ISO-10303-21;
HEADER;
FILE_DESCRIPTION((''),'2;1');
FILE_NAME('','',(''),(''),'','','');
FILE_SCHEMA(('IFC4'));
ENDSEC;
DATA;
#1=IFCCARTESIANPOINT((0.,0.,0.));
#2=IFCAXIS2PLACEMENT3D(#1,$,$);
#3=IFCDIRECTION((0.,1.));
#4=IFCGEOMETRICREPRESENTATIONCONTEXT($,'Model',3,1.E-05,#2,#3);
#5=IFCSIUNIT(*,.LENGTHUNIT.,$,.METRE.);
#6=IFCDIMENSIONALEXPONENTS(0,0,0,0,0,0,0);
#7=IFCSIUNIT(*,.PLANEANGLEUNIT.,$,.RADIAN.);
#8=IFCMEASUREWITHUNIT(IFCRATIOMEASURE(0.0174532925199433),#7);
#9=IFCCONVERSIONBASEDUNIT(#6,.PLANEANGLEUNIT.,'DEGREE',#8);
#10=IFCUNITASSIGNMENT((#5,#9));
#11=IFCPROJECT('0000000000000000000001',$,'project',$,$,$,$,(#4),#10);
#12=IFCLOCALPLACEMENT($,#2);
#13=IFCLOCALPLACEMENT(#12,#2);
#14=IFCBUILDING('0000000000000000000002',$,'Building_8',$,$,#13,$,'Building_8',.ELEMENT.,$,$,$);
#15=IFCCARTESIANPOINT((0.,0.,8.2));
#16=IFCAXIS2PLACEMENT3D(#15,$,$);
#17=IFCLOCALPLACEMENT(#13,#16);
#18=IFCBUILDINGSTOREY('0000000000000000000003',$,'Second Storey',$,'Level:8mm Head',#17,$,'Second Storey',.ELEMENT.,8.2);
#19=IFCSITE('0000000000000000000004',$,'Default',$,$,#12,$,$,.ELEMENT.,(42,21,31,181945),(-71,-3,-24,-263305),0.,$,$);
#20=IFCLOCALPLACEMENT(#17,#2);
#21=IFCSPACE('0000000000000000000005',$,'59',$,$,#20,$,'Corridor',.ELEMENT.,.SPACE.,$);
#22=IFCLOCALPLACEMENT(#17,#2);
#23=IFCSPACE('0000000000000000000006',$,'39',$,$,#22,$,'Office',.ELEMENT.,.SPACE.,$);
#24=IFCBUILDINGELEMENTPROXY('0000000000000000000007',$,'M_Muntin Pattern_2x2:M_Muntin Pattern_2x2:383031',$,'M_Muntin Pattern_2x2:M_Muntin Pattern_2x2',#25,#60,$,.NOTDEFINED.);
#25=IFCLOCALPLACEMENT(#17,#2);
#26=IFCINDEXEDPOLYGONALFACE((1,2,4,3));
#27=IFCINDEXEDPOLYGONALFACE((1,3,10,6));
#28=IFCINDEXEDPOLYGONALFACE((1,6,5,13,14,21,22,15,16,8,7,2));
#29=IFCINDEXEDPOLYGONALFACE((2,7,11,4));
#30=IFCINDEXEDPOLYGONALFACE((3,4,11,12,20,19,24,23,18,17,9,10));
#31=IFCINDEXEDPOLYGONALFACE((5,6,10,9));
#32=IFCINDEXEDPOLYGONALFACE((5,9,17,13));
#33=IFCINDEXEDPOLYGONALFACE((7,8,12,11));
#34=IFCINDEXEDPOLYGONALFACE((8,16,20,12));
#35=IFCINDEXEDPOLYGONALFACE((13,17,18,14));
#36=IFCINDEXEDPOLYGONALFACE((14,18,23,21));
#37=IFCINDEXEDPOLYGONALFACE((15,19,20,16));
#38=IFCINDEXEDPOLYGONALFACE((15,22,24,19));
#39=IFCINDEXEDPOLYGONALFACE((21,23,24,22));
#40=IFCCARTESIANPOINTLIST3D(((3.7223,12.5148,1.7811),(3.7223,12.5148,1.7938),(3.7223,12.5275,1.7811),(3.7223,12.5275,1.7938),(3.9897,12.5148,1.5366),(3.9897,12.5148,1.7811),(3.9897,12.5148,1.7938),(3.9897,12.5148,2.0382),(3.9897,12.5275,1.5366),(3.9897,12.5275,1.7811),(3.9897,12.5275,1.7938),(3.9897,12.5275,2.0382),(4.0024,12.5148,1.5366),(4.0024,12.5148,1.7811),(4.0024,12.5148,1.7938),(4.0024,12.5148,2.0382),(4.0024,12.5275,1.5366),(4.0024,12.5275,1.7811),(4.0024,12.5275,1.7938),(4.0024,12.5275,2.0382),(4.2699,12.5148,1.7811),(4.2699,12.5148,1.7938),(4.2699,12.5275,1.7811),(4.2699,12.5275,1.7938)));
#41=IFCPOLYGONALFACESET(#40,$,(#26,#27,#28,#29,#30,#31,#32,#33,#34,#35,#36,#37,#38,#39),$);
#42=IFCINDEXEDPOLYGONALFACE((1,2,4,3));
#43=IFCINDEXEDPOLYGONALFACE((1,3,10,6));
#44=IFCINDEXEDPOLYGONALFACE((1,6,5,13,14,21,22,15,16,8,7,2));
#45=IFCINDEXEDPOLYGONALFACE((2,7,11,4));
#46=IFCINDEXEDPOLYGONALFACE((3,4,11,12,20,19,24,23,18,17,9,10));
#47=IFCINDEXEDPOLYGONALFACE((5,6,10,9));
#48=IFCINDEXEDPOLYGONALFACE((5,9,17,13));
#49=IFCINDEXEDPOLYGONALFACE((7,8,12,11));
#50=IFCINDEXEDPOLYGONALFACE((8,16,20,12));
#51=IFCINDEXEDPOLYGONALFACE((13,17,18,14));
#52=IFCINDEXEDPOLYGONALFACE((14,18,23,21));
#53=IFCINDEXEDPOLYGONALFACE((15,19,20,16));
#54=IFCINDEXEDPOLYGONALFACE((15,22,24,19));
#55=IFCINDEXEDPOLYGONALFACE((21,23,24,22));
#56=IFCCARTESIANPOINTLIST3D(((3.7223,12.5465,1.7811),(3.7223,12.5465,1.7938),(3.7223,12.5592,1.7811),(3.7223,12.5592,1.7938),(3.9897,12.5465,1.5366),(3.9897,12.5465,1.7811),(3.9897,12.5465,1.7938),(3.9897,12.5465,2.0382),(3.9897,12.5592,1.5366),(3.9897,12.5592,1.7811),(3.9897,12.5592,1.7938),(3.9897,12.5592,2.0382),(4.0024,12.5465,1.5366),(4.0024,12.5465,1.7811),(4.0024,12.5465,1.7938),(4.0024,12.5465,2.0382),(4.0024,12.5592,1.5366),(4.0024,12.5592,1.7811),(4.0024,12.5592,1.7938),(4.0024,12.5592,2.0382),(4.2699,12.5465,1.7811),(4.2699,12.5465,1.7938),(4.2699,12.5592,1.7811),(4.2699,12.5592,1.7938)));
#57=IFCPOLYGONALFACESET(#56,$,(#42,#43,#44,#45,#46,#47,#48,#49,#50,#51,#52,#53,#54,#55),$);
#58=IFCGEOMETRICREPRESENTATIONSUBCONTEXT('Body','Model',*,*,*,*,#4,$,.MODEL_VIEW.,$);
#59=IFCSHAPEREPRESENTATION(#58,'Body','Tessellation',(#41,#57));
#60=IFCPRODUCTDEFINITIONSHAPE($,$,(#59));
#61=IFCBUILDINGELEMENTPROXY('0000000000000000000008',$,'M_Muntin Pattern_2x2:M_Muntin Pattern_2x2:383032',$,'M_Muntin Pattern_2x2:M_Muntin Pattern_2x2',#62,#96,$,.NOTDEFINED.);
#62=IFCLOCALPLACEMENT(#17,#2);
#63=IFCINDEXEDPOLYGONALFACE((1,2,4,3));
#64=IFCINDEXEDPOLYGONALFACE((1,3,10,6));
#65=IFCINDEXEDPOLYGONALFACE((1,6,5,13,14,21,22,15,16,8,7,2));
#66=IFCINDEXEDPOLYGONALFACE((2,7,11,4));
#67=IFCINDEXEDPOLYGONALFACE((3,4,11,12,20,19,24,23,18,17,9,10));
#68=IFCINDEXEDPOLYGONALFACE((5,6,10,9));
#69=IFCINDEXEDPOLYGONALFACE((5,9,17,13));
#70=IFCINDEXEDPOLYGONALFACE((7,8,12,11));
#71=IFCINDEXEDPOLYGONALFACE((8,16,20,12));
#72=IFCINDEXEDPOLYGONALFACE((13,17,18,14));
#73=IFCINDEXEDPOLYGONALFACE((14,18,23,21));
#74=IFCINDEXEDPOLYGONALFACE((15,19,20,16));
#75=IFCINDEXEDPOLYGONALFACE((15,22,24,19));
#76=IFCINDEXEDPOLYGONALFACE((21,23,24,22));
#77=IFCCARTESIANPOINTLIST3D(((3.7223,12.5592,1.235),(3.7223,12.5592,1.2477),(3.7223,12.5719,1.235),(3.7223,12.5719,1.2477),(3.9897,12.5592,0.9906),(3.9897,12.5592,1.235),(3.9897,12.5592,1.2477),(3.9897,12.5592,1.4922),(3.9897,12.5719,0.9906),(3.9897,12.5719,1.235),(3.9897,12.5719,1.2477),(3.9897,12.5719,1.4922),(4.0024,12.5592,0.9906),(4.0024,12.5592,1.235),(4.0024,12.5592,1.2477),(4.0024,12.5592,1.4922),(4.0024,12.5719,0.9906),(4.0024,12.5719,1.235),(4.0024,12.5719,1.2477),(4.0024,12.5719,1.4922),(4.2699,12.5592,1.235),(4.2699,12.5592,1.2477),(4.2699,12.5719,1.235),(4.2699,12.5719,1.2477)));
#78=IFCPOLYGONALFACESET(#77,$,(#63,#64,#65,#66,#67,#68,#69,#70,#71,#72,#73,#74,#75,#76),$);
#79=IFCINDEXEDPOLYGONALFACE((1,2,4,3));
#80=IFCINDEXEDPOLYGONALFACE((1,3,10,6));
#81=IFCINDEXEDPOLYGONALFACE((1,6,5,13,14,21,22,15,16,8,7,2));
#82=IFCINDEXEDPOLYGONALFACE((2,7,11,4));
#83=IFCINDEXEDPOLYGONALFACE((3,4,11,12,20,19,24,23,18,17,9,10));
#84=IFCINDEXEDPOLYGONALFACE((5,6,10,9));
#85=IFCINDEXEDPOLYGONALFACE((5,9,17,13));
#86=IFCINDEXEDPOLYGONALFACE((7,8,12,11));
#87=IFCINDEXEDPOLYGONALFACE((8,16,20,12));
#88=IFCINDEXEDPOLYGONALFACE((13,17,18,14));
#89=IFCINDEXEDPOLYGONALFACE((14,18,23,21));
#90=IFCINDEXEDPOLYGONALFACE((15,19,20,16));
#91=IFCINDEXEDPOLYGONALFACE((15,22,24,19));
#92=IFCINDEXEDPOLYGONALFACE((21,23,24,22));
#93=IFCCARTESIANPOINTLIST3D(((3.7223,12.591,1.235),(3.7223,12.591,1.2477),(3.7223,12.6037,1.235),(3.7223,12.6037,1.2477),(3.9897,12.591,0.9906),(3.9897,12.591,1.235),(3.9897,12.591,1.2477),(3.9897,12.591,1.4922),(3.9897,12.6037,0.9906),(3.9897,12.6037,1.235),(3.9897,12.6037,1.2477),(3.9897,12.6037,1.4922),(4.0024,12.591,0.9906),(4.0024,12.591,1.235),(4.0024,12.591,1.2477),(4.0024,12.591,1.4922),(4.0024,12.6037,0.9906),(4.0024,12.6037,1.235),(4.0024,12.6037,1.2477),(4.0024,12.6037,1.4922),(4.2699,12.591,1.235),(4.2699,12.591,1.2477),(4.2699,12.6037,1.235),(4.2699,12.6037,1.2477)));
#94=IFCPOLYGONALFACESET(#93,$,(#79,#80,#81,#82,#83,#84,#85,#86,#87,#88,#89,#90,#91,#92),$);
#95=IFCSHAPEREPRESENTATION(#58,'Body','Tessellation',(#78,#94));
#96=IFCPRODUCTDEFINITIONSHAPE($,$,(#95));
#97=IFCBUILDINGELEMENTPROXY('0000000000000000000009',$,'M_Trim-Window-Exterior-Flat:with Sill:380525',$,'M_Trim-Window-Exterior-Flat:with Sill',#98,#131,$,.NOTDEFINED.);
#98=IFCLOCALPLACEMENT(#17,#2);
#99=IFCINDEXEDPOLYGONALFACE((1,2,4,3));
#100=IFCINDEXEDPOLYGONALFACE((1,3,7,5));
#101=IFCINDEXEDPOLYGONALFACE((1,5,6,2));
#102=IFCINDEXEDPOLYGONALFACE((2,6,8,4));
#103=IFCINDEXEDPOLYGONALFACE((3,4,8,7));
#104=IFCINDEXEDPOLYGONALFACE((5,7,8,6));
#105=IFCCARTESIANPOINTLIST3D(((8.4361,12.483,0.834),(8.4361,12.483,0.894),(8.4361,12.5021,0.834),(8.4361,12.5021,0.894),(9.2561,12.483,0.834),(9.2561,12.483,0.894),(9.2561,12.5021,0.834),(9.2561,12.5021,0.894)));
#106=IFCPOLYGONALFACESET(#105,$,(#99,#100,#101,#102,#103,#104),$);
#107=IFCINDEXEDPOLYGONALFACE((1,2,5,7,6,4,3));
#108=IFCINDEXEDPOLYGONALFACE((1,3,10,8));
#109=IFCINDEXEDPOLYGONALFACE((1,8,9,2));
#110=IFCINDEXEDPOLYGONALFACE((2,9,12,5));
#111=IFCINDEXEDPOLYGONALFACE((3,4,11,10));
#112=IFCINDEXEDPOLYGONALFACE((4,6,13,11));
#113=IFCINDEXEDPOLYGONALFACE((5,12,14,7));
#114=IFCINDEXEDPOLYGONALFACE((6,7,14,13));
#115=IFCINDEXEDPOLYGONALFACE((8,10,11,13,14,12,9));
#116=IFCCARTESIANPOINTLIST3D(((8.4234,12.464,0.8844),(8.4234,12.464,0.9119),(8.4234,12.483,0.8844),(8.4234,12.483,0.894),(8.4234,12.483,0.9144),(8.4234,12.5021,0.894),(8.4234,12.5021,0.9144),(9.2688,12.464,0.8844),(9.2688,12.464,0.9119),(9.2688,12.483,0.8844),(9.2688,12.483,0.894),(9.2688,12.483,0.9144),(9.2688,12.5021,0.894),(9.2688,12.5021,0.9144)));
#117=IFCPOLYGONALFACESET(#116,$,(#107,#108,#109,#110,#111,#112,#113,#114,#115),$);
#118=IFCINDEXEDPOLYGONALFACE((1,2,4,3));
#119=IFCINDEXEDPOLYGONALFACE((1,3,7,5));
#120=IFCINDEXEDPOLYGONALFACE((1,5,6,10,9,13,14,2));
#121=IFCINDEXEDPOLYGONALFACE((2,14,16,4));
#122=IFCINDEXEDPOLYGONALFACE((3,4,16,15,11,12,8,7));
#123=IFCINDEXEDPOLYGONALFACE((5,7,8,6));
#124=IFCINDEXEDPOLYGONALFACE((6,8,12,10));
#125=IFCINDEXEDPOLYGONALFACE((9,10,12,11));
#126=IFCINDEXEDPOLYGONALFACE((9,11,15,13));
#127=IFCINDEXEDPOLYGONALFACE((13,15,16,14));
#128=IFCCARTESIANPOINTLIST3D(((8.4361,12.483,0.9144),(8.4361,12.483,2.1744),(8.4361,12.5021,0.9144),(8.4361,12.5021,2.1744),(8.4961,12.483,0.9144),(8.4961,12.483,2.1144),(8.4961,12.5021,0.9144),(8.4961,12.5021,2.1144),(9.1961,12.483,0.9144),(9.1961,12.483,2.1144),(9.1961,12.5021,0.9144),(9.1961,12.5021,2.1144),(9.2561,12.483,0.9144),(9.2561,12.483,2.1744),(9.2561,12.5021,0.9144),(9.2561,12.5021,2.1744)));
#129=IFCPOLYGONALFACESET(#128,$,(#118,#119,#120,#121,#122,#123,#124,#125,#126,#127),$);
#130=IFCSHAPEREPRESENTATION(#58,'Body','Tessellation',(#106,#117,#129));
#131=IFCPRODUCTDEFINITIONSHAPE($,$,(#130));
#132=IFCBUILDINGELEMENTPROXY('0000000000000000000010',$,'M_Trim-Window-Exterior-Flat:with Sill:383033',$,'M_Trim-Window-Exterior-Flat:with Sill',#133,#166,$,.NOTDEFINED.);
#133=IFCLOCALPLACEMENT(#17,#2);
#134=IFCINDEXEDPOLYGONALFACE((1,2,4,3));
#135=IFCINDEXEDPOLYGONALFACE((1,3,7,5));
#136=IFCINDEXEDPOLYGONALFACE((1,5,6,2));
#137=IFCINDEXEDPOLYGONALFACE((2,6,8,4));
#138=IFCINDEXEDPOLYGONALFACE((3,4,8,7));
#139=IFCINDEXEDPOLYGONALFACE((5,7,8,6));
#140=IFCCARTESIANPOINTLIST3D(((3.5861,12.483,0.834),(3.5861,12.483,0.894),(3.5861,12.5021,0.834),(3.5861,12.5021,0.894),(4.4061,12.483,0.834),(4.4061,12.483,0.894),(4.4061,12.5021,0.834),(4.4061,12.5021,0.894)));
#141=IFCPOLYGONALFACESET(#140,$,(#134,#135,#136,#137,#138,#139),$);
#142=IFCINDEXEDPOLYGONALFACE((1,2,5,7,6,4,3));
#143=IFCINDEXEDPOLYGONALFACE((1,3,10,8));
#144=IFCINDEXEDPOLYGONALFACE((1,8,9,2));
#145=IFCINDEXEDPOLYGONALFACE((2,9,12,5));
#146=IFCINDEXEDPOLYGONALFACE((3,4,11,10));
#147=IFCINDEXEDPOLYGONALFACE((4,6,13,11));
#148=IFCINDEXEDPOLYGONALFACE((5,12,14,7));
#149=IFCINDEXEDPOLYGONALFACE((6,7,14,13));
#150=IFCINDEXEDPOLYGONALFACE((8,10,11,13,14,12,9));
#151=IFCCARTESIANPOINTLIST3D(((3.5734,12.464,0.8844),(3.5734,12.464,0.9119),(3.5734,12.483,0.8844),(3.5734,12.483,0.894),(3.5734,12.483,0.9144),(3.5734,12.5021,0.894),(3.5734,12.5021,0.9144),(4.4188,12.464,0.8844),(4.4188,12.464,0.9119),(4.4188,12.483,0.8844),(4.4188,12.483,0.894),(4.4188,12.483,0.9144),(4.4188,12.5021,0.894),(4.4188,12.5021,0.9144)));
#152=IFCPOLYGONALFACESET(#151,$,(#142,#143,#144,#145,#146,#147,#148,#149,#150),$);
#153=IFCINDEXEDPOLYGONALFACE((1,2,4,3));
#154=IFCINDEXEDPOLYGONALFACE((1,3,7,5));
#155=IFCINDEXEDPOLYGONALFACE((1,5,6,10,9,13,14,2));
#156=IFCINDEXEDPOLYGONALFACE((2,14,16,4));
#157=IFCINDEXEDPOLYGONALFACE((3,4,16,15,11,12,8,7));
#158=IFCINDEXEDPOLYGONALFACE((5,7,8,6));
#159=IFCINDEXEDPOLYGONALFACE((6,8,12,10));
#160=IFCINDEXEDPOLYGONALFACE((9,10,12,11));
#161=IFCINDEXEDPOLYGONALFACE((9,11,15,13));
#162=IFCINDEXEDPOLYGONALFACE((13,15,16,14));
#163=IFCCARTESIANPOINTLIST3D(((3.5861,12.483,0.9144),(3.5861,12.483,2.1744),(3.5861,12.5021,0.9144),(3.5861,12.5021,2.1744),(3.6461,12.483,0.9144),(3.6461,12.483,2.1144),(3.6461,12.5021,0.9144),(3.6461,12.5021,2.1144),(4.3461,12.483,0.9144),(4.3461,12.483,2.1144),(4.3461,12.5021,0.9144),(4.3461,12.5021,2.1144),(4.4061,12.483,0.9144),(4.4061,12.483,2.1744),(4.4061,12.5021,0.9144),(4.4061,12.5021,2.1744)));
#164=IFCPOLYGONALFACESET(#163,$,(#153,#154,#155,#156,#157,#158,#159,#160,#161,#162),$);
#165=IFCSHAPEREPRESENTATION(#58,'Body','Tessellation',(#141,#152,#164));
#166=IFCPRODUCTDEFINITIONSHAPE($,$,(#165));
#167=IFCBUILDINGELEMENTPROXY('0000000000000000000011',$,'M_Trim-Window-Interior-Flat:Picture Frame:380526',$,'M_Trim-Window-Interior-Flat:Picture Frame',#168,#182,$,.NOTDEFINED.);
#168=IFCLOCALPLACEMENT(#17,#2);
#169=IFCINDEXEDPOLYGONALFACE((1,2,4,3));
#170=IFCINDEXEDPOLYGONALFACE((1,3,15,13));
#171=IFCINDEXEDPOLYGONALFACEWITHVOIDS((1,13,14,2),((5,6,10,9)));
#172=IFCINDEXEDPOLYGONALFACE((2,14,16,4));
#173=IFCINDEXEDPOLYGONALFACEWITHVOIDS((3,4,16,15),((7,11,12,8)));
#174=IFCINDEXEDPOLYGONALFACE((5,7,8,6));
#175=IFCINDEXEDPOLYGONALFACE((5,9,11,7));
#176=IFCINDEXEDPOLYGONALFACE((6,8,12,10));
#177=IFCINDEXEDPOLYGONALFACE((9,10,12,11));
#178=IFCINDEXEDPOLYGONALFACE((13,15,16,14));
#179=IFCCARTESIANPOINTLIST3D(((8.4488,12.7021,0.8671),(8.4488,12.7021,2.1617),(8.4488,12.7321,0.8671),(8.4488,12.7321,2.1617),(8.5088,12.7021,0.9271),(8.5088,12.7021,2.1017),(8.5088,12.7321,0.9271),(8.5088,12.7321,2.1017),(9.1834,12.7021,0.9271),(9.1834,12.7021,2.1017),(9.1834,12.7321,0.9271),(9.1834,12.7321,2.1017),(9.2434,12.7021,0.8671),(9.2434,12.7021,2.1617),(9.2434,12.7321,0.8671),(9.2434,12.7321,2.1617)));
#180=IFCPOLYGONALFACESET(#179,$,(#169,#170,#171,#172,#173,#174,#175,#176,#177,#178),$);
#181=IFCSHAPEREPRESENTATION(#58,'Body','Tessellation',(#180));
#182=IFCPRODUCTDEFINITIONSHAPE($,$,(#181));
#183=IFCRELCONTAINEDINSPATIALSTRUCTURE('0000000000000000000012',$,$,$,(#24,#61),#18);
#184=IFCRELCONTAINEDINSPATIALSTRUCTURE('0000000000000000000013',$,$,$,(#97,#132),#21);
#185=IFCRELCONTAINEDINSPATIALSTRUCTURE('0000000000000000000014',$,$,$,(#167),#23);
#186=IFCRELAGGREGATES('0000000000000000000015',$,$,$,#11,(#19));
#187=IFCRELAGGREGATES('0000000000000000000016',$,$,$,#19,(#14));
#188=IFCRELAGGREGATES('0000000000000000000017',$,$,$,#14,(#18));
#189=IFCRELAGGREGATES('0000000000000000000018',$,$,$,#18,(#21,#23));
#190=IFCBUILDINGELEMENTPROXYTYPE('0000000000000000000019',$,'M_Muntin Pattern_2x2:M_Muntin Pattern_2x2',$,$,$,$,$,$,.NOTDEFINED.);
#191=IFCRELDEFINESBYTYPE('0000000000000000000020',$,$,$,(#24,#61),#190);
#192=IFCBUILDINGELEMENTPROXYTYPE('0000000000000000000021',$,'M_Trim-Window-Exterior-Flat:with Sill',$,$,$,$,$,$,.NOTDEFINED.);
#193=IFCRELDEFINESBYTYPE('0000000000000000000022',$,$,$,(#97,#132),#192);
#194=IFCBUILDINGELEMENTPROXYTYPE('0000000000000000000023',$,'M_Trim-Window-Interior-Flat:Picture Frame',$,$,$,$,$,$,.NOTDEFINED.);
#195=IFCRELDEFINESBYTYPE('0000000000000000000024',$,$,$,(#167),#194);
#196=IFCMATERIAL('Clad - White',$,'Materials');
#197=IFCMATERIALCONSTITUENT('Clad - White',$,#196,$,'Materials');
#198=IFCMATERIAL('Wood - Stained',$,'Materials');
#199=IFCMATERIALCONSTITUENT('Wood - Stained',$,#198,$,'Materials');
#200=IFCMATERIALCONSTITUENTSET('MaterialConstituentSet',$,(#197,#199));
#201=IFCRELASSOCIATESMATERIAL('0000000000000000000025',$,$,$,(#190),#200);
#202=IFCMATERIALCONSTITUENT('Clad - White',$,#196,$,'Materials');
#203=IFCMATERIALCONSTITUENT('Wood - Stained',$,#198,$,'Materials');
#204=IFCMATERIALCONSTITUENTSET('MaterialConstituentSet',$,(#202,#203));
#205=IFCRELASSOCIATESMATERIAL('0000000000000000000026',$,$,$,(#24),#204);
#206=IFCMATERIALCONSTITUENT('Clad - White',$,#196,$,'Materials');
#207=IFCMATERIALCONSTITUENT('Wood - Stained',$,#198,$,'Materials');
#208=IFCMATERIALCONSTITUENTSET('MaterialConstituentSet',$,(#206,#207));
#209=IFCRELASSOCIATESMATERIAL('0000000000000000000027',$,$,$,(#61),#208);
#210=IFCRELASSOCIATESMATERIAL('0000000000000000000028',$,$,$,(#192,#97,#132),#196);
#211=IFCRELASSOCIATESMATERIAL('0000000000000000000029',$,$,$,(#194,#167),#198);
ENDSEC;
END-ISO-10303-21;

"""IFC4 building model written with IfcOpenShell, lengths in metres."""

from ifc_helpers import new_model, entity, si_unit, converted_unit, direction, frame, origin, place, context, subcontext, project, spatial, indexed_curve, outline, extrude, source, transform, mapped, material, constituent, constituent_set, type_object, type_shapes, element, save


model = new_model("IFC4")

# Units and contexts
model_context = context("Model", 3, precision=1e-05, world=origin(), true_north=direction((0.0, 1.0)))
body_context = subcontext(model_context, "Body", "Model", "MODEL_VIEW")
ifc_project = project(units=[si_unit("LENGTHUNIT", "METRE"), converted_unit("PLANEANGLEUNIT", "DEGREE", entity("IfcRatioMeasure", 0.0174532925199433), si_unit("PLANEANGLEUNIT", "RADIAN"), dimensions=[0, 0, 0, 0, 0, 0, 0])], contexts=[model_context])

# Site, building, storey
site_placement = place(None, origin())
site = spatial("IfcSite", under=ifc_project, at=site_placement, Name="Default", CompositionType="ELEMENT", RefLatitude=(42, 21, 31, 181945), RefLongitude=(-71, -3, -24, -263305), RefElevation=0.0)
building_placement = place(site_placement, origin())
building = spatial("IfcBuilding", under=site, at=building_placement, Name="Building_8", LongName="Building_8", CompositionType="ELEMENT")
storey_placement = place(building_placement, frame((0.0, 0.0, 8.2)))
storey = spatial("IfcBuildingStorey", under=building, at=storey_placement, Name="Second Storey", ObjectType="Level:8mm Head", LongName="Second Storey", CompositionType="ELEMENT", Elevation=8.2)

# Building element proxies
ifc_material_1 = material(Name="Clad - White", Category="Materials")
ifc_material_2 = material(Name="Wood - Stained", Category="Materials")
ifc_constituent_1 = constituent(ifc_material_1, Name="Clad - White", Category="Materials")
ifc_constituent_2 = constituent(ifc_material_2, Name="Wood - Stained", Category="Materials")
ifc_constituent_set_1 = constituent_set(constituents=[ifc_constituent_1, ifc_constituent_2], Name="MaterialConstituentSet")
building_element_proxy_type_1 = type_object("IfcBuildingElementProxyType", Name="M_Muntin Pattern_2x2:M_Muntin Pattern_2x2", PredefinedType="NOTDEFINED", material=ifc_constituent_set_1)
shared_shape_1 = source(origin(), body_context, "Body", "SweptSolid", [
    extrude(outline(indexed_curve([(0.0064, -0.0064), (0.2508, -0.0064), (0.2508, 0.0063), (0.0064, 0.0063), (0.0064, 0.2738), (-0.0063, 0.2738), (-0.0063, 0.0063), (-0.2508, 0.0063), (-0.2508, -0.0064), (-0.0063, -0.0064), (-0.0063, -0.2738), (0.0064, -0.2738), (0.0064, -0.0064)], self_intersect=False)), frame((0.0, -0.0222, 0.2508), z_axis=(0.0, 1.0, 0.0), x_axis=(0.0, 0.0, 1.0)), (0.0, 0.0, 1.0), 0.0127),
    extrude(outline(indexed_curve([(0.0064, -0.0064), (0.2508, -0.0064), (0.2508, 0.0063), (0.0064, 0.0063), (0.0064, 0.2738), (-0.0063, 0.2738), (-0.0063, 0.0063), (-0.2508, 0.0063), (-0.2508, -0.0064), (-0.0063, -0.0064), (-0.0063, -0.2738), (0.0064, -0.2738), (0.0064, -0.0064)], self_intersect=False)), frame((0.0, 0.0095, 0.2508), z_axis=(0.0, 1.0, 0.0), x_axis=(0.0, 0.0, 1.0)), (0.0, 0.0, 1.0), 0.0127),
])
type_shapes(building_element_proxy_type_1, [shared_shape_1])
ifc_constituent_3 = constituent(ifc_material_1, Name="Clad - White", Category="Materials")
ifc_constituent_4 = constituent(ifc_material_2, Name="Wood - Stained", Category="Materials")
ifc_constituent_set_2 = constituent_set(constituents=[ifc_constituent_3, ifc_constituent_4], Name="MaterialConstituentSet")
proxy_1_placement = place(storey_placement, frame((3.9961, 12.537, 1.5366)))
element("IfcBuildingElementProxy", 1, at=proxy_1_placement, inside=storey, type_object=building_element_proxy_type_1, material=ifc_constituent_set_2, Name="M_Muntin Pattern_2x2:M_Muntin Pattern_2x2:383031", ObjectType="M_Muntin Pattern_2x2:M_Muntin Pattern_2x2", PredefinedType="NOTDEFINED", context=body_context, shape_type="MappedRepresentation", body=[
    mapped(shared_shape_1, transform((0.0, 0.0, 0.0), scale=1.0)),
])
ifc_constituent_5 = constituent(ifc_material_1, Name="Clad - White", Category="Materials")
ifc_constituent_6 = constituent(ifc_material_2, Name="Wood - Stained", Category="Materials")
ifc_constituent_set_3 = constituent_set(constituents=[ifc_constituent_5, ifc_constituent_6], Name="MaterialConstituentSet")
proxy_2_placement = place(storey_placement, frame((3.9961, 12.5814, 0.9906)))
element("IfcBuildingElementProxy", 2, at=proxy_2_placement, inside=storey, type_object=building_element_proxy_type_1, material=ifc_constituent_set_3, Name="M_Muntin Pattern_2x2:M_Muntin Pattern_2x2:383032", ObjectType="M_Muntin Pattern_2x2:M_Muntin Pattern_2x2", PredefinedType="NOTDEFINED", context=body_context, shape_type="MappedRepresentation", body=[
    mapped(shared_shape_1, transform((0.0, 0.0, 0.0), scale=1.0)),
])

# Shared definitions
space_1_placement = place(storey_placement, origin())
space_1 = spatial("IfcSpace", under=storey, at=space_1_placement, Name="59", LongName="Corridor", CompositionType="ELEMENT", PredefinedType="SPACE")

# Building element proxies
building_element_proxy_type_2 = type_object("IfcBuildingElementProxyType", Name="M_Trim-Window-Exterior-Flat:with Sill", PredefinedType="NOTDEFINED", material=ifc_material_1)
shared_shape_2 = source(origin(), body_context, "Body", "SweptSolid", [
    extrude(outline(indexed_curve([(-0.03, -0.41), (0.03, -0.41), (0.03, 0.41), (-0.03, 0.41), (-0.03, -0.41)], self_intersect=False)), frame((0.0, 1.2504, 0.0), z_axis=(0.0, 0.0, 1.0), x_axis=(0.0, 1.0, 0.0)), (0.0, 0.0, 1.0), 0.0191),
    extrude(outline(indexed_curve([(-0.0152, -0.019), (0.0123, -0.019), (0.0148, 0.0), (0.0148, 0.019), (-0.0057, 0.019), (-0.0057, 0.0), (-0.0152, 0.0), (-0.0152, -0.019)], self_intersect=False)), frame((-0.4227, 1.2148, 0.019), z_axis=(1.0, 0.0, 0.0), x_axis=(0.0, -1.0, 0.0)), (0.0, 0.0, 1.0), 0.8454),
    extrude(outline(indexed_curve([(-0.41, -0.645), (0.41, -0.645), (0.41, 0.615), (0.35, 0.615), (0.35, -0.585), (-0.35, -0.585), (-0.35, 0.615), (-0.41, 0.615), (-0.41, -0.645)], self_intersect=False)), frame((0.0, 0.585, 0.0)), (0.0, 0.0, 1.0), 0.0191),
])
type_shapes(building_element_proxy_type_2, [shared_shape_2])
for number, where, z_axis, x_axis, name in (
    (3, (8.8461, 12.5021, 2.1144), (0.0, -1.0, 0.0), (-1.0, 0.0, 0.0), "M_Trim-Window-Exterior-Flat:with Sill:380525"),
    (4, (3.9961, 12.5021, 2.1144), (0.0, -1.0, 0.0), (-1.0, 0.0, 0.0), "M_Trim-Window-Exterior-Flat:with Sill:383033"),
):
    element("IfcBuildingElementProxy", number, at=place(space_1_placement, frame(where, z_axis=z_axis, x_axis=x_axis)), inside=space_1, type_object=building_element_proxy_type_2, material=ifc_material_1, Name=name, ObjectType="M_Trim-Window-Exterior-Flat:with Sill", PredefinedType="NOTDEFINED", context=body_context, shape_type="MappedRepresentation", body=[
        mapped(shared_shape_2, transform((0.0, 0.0, 0.0), scale=1.0)),
    ])

# Shared definitions
space_2_placement = place(storey_placement, origin())
space_2 = spatial("IfcSpace", under=storey, at=space_2_placement, Name="39", LongName="Office", CompositionType="ELEMENT", PredefinedType="SPACE")

# Building element proxy
building_element_proxy_type_3 = type_object("IfcBuildingElementProxyType", Name="M_Trim-Window-Interior-Flat:Picture Frame", PredefinedType="NOTDEFINED", material=ifc_material_2)
shared_shape_3 = source(origin(), body_context, "Body", "SweptSolid", [
    extrude(outline(indexed_curve([(-0.6473, -0.3973), (0.6473, -0.3973), (0.6473, 0.3973), (-0.6473, 0.3973), (-0.6473, -0.3973)], self_intersect=False), holes=[indexed_curve([(-0.5873, -0.3373), (-0.5873, 0.3373), (0.5873, 0.3373), (0.5873, -0.3373), (-0.5873, -0.3373)], self_intersect=False)]), frame((0.0, 0.6, 0.0), z_axis=(0.0, 0.0, 1.0), x_axis=(0.0, 1.0, 0.0)), (0.0, 0.0, 1.0), 0.03),
])
type_shapes(building_element_proxy_type_3, [shared_shape_3])
proxy_3_placement = place(space_2_placement, frame((8.8461, 12.7021, 2.1144), z_axis=(0.0, 1.0, 0.0), x_axis=(1.0, 0.0, 0.0)))
element("IfcBuildingElementProxy", 5, at=proxy_3_placement, inside=space_2, type_object=building_element_proxy_type_3, material=ifc_material_2, Name="M_Trim-Window-Interior-Flat:Picture Frame:380526", ObjectType="M_Trim-Window-Interior-Flat:Picture Frame", PredefinedType="NOTDEFINED", context=body_context, shape_type="MappedRepresentation", body=[
    mapped(shared_shape_3, transform((0.0, 0.0, 0.0), scale=1.0)),
])

save(model, "model.ifc")
